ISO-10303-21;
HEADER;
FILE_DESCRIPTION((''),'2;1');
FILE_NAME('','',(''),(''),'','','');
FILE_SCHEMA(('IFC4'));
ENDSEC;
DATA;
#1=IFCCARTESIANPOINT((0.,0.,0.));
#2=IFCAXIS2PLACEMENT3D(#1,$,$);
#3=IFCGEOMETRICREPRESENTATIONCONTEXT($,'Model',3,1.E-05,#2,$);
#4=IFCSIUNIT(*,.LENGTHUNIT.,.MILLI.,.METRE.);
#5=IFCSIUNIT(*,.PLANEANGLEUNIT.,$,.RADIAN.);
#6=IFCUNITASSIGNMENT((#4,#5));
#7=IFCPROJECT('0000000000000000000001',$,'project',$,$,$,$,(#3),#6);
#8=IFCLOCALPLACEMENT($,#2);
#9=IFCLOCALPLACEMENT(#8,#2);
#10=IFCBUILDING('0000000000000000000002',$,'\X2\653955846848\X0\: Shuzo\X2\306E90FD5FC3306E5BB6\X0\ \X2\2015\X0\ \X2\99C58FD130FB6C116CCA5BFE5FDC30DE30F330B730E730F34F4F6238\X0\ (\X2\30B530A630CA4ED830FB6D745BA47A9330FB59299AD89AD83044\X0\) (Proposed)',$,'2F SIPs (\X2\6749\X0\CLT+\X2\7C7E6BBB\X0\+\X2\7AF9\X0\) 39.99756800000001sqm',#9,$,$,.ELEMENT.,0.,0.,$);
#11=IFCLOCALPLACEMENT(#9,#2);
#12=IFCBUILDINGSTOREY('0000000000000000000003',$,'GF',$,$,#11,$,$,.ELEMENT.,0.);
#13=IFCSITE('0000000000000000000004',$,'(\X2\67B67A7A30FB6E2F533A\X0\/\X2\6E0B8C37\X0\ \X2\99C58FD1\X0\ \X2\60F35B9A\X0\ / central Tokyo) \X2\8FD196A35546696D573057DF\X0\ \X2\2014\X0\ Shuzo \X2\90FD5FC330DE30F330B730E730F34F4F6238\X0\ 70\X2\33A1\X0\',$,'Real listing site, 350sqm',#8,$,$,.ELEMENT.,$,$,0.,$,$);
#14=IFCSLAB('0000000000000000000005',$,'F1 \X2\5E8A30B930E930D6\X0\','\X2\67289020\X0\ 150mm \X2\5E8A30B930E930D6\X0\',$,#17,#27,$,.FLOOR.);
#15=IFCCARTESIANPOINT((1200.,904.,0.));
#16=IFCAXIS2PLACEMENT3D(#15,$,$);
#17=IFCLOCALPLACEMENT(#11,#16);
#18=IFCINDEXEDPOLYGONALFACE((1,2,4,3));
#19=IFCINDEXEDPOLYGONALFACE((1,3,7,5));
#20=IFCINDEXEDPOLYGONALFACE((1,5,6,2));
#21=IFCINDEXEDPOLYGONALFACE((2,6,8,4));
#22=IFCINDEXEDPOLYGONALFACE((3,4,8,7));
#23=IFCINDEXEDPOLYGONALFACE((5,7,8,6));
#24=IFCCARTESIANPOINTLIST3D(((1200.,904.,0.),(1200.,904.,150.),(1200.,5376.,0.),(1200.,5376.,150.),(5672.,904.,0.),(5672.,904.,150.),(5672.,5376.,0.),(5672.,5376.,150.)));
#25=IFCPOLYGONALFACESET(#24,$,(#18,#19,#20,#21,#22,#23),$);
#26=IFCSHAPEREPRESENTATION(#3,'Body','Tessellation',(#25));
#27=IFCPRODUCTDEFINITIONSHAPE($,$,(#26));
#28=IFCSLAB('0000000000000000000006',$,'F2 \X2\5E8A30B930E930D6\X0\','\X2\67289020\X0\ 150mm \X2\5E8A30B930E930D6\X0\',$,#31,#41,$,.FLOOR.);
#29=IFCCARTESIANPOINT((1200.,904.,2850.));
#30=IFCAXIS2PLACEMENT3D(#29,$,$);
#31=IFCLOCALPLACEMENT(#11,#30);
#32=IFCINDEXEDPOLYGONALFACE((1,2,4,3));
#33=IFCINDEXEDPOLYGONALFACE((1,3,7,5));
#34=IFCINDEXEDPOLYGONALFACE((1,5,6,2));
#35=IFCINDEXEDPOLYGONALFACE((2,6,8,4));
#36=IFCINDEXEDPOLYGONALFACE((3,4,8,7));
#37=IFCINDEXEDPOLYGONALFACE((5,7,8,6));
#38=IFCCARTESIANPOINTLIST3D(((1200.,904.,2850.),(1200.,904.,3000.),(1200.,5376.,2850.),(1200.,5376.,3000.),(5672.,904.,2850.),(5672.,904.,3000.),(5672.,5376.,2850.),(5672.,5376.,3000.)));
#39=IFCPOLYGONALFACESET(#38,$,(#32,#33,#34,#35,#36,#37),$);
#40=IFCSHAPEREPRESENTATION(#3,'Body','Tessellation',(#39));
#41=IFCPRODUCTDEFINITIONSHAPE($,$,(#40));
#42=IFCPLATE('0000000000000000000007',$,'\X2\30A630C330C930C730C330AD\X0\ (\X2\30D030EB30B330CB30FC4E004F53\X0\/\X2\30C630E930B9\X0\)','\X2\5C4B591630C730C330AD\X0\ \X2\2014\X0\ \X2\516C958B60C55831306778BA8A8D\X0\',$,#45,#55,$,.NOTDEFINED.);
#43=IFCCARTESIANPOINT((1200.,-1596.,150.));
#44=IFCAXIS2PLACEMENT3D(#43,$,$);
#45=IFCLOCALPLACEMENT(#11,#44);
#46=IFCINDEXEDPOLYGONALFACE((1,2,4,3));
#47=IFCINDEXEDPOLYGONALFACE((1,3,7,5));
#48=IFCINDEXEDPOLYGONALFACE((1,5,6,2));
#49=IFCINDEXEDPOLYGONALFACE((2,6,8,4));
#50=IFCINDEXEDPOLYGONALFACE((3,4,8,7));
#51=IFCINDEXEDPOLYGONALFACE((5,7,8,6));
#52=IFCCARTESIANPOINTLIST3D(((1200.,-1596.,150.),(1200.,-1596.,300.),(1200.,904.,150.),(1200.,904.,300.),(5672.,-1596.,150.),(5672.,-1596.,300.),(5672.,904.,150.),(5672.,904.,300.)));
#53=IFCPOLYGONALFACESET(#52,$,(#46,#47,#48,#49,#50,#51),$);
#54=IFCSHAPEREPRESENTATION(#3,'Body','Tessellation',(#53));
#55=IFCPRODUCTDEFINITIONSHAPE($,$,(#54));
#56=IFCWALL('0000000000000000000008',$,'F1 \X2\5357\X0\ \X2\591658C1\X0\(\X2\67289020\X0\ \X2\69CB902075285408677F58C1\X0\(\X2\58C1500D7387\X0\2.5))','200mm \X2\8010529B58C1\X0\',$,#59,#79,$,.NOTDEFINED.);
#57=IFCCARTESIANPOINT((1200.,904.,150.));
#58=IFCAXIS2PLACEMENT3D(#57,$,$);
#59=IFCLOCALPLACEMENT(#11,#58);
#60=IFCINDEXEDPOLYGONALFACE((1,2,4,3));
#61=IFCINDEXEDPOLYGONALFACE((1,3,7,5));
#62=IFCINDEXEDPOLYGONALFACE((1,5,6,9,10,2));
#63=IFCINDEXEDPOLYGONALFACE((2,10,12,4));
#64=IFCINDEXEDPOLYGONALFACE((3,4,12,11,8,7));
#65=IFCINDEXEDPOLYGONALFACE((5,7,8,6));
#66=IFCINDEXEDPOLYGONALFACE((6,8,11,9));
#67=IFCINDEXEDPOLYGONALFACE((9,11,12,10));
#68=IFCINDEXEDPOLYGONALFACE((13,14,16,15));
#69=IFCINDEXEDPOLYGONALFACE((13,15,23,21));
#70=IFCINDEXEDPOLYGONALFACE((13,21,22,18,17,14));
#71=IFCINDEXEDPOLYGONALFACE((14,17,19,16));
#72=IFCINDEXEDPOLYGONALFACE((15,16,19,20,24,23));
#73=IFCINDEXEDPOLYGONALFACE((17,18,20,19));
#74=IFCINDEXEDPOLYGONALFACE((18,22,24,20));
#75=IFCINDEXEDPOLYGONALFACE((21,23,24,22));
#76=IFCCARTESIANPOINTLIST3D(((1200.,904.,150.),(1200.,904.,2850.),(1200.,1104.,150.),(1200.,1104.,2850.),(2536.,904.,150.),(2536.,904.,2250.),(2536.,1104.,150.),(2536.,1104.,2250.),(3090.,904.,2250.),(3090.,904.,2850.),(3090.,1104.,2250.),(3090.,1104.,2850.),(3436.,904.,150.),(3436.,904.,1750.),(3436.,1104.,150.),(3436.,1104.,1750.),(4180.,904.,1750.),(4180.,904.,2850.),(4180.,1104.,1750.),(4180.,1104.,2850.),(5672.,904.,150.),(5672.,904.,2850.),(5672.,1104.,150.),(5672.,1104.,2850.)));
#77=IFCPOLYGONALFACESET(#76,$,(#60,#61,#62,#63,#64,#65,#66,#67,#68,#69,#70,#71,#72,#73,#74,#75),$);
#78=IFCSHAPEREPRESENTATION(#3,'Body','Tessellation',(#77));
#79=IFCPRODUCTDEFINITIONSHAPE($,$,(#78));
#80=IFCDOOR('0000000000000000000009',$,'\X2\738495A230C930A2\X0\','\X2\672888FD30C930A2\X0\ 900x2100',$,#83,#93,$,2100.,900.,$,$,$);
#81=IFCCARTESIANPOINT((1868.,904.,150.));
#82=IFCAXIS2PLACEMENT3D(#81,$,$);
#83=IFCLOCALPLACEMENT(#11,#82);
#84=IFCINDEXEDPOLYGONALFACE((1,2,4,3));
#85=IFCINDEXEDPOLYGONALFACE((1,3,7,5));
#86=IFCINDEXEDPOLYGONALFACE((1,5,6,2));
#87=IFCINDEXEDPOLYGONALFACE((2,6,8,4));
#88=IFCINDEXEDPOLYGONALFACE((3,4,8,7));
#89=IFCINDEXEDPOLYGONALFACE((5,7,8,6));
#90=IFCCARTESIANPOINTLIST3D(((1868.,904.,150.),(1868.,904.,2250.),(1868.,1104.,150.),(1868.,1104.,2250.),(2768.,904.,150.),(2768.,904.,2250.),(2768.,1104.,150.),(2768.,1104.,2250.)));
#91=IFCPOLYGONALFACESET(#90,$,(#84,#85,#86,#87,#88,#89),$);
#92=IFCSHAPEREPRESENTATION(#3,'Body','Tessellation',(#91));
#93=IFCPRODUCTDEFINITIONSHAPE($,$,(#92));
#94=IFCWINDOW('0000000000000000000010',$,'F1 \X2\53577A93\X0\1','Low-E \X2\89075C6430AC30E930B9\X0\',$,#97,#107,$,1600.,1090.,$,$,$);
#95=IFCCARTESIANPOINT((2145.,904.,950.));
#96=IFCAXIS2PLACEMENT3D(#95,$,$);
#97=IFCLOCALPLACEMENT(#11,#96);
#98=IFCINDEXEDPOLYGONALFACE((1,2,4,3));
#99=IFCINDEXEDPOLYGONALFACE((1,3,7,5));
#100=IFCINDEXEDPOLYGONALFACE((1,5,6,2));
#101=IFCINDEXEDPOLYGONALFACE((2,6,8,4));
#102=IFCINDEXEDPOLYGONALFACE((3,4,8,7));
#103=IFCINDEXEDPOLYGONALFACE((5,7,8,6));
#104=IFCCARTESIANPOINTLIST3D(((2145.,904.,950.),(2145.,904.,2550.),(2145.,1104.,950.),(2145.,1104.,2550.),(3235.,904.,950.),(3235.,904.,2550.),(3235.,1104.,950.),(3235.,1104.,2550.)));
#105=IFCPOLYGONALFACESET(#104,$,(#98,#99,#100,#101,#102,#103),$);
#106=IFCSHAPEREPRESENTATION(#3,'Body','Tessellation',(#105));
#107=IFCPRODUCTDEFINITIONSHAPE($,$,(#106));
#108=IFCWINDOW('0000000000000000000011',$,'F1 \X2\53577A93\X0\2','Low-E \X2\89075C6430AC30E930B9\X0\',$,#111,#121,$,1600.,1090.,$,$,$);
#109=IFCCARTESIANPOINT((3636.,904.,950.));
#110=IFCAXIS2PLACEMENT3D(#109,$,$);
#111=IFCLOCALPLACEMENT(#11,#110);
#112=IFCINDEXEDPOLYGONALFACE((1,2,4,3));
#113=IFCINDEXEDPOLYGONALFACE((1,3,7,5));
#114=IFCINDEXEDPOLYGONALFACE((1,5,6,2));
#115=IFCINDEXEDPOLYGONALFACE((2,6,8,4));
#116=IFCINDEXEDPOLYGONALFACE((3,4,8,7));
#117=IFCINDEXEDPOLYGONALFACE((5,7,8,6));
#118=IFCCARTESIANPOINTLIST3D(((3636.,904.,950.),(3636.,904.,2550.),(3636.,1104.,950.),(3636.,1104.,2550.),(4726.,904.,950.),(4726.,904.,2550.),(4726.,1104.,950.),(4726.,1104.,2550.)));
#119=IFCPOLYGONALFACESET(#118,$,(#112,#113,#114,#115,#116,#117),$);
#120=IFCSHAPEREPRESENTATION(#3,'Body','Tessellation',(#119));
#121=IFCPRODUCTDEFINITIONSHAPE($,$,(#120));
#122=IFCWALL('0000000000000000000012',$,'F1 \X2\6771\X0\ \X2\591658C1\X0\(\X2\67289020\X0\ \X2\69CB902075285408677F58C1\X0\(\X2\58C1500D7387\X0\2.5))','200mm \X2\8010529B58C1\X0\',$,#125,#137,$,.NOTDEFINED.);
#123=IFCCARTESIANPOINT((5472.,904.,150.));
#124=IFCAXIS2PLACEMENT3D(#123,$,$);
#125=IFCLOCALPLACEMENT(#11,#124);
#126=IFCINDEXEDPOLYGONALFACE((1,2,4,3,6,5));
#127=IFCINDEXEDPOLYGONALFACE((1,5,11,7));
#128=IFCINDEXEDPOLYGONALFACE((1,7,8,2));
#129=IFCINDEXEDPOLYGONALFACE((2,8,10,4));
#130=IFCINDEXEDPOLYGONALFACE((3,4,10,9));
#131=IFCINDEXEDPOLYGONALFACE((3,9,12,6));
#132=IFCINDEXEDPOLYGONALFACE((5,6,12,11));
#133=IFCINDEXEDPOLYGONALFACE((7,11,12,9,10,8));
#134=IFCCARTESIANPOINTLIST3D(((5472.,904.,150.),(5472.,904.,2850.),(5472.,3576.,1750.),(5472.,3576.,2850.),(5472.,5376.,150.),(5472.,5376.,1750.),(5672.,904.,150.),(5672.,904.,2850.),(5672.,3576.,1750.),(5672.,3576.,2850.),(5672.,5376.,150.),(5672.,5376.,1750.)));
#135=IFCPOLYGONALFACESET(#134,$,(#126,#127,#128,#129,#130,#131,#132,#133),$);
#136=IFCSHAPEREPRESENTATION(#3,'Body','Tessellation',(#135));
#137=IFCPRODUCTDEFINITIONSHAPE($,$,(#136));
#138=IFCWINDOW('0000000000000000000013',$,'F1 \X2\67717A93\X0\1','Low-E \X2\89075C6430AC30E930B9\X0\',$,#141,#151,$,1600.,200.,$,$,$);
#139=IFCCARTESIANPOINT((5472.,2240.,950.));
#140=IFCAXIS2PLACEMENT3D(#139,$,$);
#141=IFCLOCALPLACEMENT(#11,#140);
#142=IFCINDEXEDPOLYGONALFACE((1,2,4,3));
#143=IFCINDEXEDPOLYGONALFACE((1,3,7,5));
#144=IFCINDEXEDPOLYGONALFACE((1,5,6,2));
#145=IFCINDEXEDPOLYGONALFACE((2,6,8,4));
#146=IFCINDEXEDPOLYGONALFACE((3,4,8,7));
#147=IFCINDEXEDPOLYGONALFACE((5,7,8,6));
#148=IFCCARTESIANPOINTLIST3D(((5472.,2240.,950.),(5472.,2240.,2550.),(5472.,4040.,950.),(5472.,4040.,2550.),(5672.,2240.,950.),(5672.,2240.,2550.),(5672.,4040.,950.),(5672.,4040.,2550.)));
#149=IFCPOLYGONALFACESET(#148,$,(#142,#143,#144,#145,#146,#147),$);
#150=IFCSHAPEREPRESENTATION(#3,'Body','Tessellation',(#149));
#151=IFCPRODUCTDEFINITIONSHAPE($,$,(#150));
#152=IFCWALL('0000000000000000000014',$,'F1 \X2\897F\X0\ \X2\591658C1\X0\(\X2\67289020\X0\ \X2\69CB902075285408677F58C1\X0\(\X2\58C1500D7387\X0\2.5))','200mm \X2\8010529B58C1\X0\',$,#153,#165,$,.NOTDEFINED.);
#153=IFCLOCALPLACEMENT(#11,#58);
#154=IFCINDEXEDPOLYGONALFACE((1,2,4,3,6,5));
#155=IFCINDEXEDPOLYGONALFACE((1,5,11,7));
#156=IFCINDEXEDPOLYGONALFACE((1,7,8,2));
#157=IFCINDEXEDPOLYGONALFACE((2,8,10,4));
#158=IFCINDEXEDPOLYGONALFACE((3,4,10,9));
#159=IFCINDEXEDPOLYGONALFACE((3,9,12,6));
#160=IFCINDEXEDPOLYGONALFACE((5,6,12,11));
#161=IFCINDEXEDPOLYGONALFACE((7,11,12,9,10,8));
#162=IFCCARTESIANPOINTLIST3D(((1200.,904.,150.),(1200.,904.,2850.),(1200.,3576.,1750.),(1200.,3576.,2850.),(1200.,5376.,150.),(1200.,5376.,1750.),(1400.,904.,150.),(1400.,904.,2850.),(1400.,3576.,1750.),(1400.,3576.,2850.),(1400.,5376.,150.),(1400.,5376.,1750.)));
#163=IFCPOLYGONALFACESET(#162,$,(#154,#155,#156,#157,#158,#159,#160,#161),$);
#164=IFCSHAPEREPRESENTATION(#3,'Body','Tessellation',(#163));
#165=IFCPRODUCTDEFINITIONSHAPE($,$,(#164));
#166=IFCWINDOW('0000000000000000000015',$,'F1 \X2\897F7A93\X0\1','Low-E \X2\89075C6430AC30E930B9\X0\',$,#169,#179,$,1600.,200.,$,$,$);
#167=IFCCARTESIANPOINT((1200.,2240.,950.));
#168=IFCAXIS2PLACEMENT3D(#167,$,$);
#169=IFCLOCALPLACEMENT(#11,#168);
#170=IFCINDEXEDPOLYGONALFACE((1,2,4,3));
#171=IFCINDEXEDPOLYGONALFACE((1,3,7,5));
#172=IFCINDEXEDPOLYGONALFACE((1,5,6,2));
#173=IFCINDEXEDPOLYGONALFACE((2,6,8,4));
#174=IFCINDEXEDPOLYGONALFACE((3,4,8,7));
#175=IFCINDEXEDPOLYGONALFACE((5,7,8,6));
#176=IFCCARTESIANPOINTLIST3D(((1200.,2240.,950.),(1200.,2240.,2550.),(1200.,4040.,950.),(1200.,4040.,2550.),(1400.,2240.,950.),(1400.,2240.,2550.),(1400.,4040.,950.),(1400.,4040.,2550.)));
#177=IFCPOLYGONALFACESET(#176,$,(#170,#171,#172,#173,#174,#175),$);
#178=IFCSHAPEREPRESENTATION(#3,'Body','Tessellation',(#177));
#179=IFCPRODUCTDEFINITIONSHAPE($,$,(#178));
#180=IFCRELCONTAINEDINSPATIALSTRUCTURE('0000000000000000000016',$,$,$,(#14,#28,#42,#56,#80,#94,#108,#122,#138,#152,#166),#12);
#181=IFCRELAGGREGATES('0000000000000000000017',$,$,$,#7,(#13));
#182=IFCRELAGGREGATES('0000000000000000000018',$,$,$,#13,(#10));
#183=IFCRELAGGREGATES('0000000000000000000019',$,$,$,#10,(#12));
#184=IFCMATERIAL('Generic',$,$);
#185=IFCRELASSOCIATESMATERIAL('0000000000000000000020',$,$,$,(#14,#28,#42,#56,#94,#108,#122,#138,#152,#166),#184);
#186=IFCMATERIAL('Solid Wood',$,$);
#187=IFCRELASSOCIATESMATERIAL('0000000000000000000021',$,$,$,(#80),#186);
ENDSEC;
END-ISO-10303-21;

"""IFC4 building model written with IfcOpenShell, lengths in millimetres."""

from ifc_helpers import new_model, si_unit, frame, frame_2d, origin, place, context, project, spatial, rectangle, extrude, material, element, fill, save


model = new_model("IFC4")

# Units and contexts
model_context = context("Model", 3, precision=1e-05, world=origin())
ifc_project = project(units=[si_unit("LENGTHUNIT", "METRE", prefix="MILLI"), si_unit("PLANEANGLEUNIT", "RADIAN")], contexts=[model_context])

# Site, building, storey
site_placement = place(None, origin())
site = spatial("IfcSite", under=ifc_project, at=site_placement, Name="(架空・港区/渋谷 駅近 想定 / central Tokyo) 近隣商業地域 — Shuzo 都心マンション住戸 70㎡", ObjectType="Real listing site, 350sqm", CompositionType="ELEMENT", RefElevation=0.0)
building_placement = place(site_placement, origin())
building = spatial("IfcBuilding", under=site, at=building_placement, Name="改善案: Shuzoの都心の家 ― 駅近・民泊対応マンション住戸 (サウナ付・浴室窓・天高高い) (Proposed)", ObjectType="2F SIPs (杉CLT+籾殻+竹) 39.99756800000001sqm", CompositionType="ELEMENT", ElevationOfRefHeight=0.0, ElevationOfTerrain=0.0)
storey_placement = place(building_placement, origin())
storey = spatial("IfcBuildingStorey", under=building, at=storey_placement, Name="GF", CompositionType="ELEMENT", Elevation=0.0)

# Slabs
ifc_material_1 = material(Name="Generic")
slab_1_placement = place(storey_placement, frame((1200.0, 904.0, 0.0)))
element("IfcSlab", 1, at=slab_1_placement, inside=storey, material=ifc_material_1, Name="F1 床スラブ", Description="木造 150mm 床スラブ", PredefinedType="FLOOR", context=model_context, shape_type="SweptSolid", body=[
    extrude(rectangle(XDim=4472.0, YDim=4472.0, at=frame_2d((2236.0, 2236.0))), frame((1200.0, 904.0, 0.0)), (0.0, 0.0, 1.0), 150.0),
])
slab_2_placement = place(storey_placement, frame((1200.0, 904.0, 2850.0)))
element("IfcSlab", 2, at=slab_2_placement, inside=storey, material=ifc_material_1, Name="F2 床スラブ", Description="木造 150mm 床スラブ", PredefinedType="FLOOR", context=model_context, shape_type="SweptSolid", body=[
    extrude(rectangle(XDim=4472.0, YDim=4472.0, at=frame_2d((2236.0, 2236.0))), frame((1200.0, 904.0, 2850.0)), (0.0, 0.0, 1.0), 150.0),
])

# Plate
plate_placement = place(storey_placement, frame((1200.0, -1596.0, 150.0)))
element("IfcPlate", 3, at=plate_placement, inside=storey, material=ifc_material_1, Name="ウッドデッキ (バルコニー一体/テラス)", Description="屋外デッキ — 公開情報で確認", PredefinedType="NOTDEFINED", context=model_context, shape_type="SweptSolid", body=[
    extrude(rectangle(XDim=4472.0, YDim=2500.0, at=frame_2d((2236.0, 1250.0))), frame((1200.0, -1596.0, 150.0)), (0.0, 0.0, 1.0), 150.0),
])

# Wall, openings, door, windows
wall_1_placement = place(storey_placement, frame((1200.0, 904.0, 150.0)))
wall_1 = element("IfcWall", 4, at=wall_1_placement, inside=storey, material=ifc_material_1, Name="F1 南 外壁(木造 構造用合板壁(壁倍率2.5))", Description="200mm 耐力壁", PredefinedType="NOTDEFINED", context=model_context, shape_type="SweptSolid", body=[
    extrude(rectangle(XDim=4472.0, YDim=200.0, at=frame_2d((2236.0, 100.0))), frame((1200.0, 904.0, 150.0)), (0.0, 0.0, 1.0), 2700.0),
])
opening_1_placement = place(storey_placement, frame((1868.0, 904.0, 150.0)))
opening_1 = element("IfcOpeningElement", 5, at=opening_1_placement, cuts=wall_1, PredefinedType="NOTDEFINED", context=model_context, shape_type="SweptSolid", body=[
    extrude(rectangle(XDim=900.0, YDim=200.0, at=frame_2d((450.0, 100.0))), frame((1868.0, 904.0, 150.0)), (0.0, 0.0, 1.0), 2100.0),
])
opening_2_placement = place(storey_placement, frame((2145.0, 904.0, 950.0)))
opening_2 = element("IfcOpeningElement", 6, at=opening_2_placement, cuts=wall_1, PredefinedType="NOTDEFINED", context=model_context, shape_type="SweptSolid", body=[
    extrude(rectangle(XDim=1090.0, YDim=200.0, at=frame_2d((545.0, 100.0))), frame((2145.0, 904.0, 950.0)), (0.0, 0.0, 1.0), 1600.0),
])
opening_3_placement = place(storey_placement, frame((3636.0, 904.0, 950.0)))
opening_3 = element("IfcOpeningElement", 7, at=opening_3_placement, cuts=wall_1, PredefinedType="NOTDEFINED", context=model_context, shape_type="SweptSolid", body=[
    extrude(rectangle(XDim=1090.0, YDim=200.0, at=frame_2d((545.0, 100.0))), frame((3636.0, 904.0, 950.0)), (0.0, 0.0, 1.0), 1600.0),
])
ifc_material_2 = material(Name="Solid Wood")
door_placement = place(storey_placement, frame((1868.0, 904.0, 150.0)))
door = element("IfcDoor", 8, at=door_placement, inside=storey, material=ifc_material_2, Name="玄関ドア", Description="木製ドア 900x2100", OverallHeight=2100.0, OverallWidth=900.0, context=model_context, shape_type="SweptSolid", body=[
    extrude(rectangle(XDim=900.0, YDim=200.0, at=frame_2d((450.0, 100.0))), frame((1868.0, 904.0, 150.0)), (0.0, 0.0, 1.0), 2100.0),
])
fill(opening_1, door)
window_1_placement = place(storey_placement, frame((2145.0, 904.0, 950.0)))
window_1 = element("IfcWindow", 9, at=window_1_placement, inside=storey, material=ifc_material_1, Name="F1 南窓1", Description="Low-E 複層ガラス", OverallHeight=1600.0, OverallWidth=1090.0, context=model_context, shape_type="SweptSolid", body=[
    extrude(rectangle(XDim=1090.0, YDim=200.0, at=frame_2d((545.0, 100.0))), frame((2145.0, 904.0, 950.0)), (0.0, 0.0, 1.0), 1600.0),
])
fill(opening_2, window_1)
window_2_placement = place(storey_placement, frame((3636.0, 904.0, 950.0)))
window_2 = element("IfcWindow", 10, at=window_2_placement, inside=storey, material=ifc_material_1, Name="F1 南窓2", Description="Low-E 複層ガラス", OverallHeight=1600.0, OverallWidth=1090.0, context=model_context, shape_type="SweptSolid", body=[
    extrude(rectangle(XDim=1090.0, YDim=200.0, at=frame_2d((545.0, 100.0))), frame((3636.0, 904.0, 950.0)), (0.0, 0.0, 1.0), 1600.0),
])
fill(opening_3, window_2)

# Walls, openings, windows
wall_2_placement = place(storey_placement, frame((5472.0, 904.0, 150.0)))
wall_2 = element("IfcWall", 11, at=wall_2_placement, inside=storey, material=ifc_material_1, Name="F1 東 外壁(木造 構造用合板壁(壁倍率2.5))", Description="200mm 耐力壁", PredefinedType="NOTDEFINED", context=model_context, shape_type="SweptSolid", body=[
    extrude(rectangle(XDim=200.0, YDim=4472.0, at=frame_2d((100.0, 2236.0))), frame((5472.0, 904.0, 150.0)), (0.0, 0.0, 1.0), 2700.0),
])
opening_4_placement = place(storey_placement, frame((5472.0, 2240.0, 950.0)))
opening_4 = element("IfcOpeningElement", 12, at=opening_4_placement, cuts=wall_2, PredefinedType="NOTDEFINED", context=model_context, shape_type="SweptSolid", body=[
    extrude(rectangle(XDim=200.0, YDim=1800.0, at=frame_2d((100.0, 900.0))), frame((5472.0, 2240.0, 950.0)), (0.0, 0.0, 1.0), 1600.0),
])
window_3_placement = place(storey_placement, frame((5472.0, 2240.0, 950.0)))
window_3 = element("IfcWindow", 13, at=window_3_placement, inside=storey, material=ifc_material_1, Name="F1 東窓1", Description="Low-E 複層ガラス", OverallHeight=1600.0, OverallWidth=200.0, context=model_context, shape_type="SweptSolid", body=[
    extrude(rectangle(XDim=200.0, YDim=1800.0, at=frame_2d((100.0, 900.0))), frame((5472.0, 2240.0, 950.0)), (0.0, 0.0, 1.0), 1600.0),
])
fill(opening_4, window_3)
wall_3_placement = place(storey_placement, frame((1200.0, 904.0, 150.0)))
wall_3 = element("IfcWall", 14, at=wall_3_placement, inside=storey, material=ifc_material_1, Name="F1 西 外壁(木造 構造用合板壁(壁倍率2.5))", Description="200mm 耐力壁", PredefinedType="NOTDEFINED", context=model_context, shape_type="SweptSolid", body=[
    extrude(rectangle(XDim=200.0, YDim=4472.0, at=frame_2d((100.0, 2236.0))), frame((1200.0, 904.0, 150.0)), (0.0, 0.0, 1.0), 2700.0),
])
opening_5_placement = place(storey_placement, frame((1200.0, 2240.0, 950.0)))
opening_5 = element("IfcOpeningElement", 15, at=opening_5_placement, cuts=wall_3, PredefinedType="NOTDEFINED", context=model_context, shape_type="SweptSolid", body=[
    extrude(rectangle(XDim=200.0, YDim=1800.0, at=frame_2d((100.0, 900.0))), frame((1200.0, 2240.0, 950.0)), (0.0, 0.0, 1.0), 1600.0),
])
window_4_placement = place(storey_placement, frame((1200.0, 2240.0, 950.0)))
window_4 = element("IfcWindow", 16, at=window_4_placement, inside=storey, material=ifc_material_1, Name="F1 西窓1", Description="Low-E 複層ガラス", OverallHeight=1600.0, OverallWidth=200.0, context=model_context, shape_type="SweptSolid", body=[
    extrude(rectangle(XDim=200.0, YDim=1800.0, at=frame_2d((100.0, 900.0))), frame((1200.0, 2240.0, 950.0)), (0.0, 0.0, 1.0), 1600.0),
])
fill(opening_5, window_4)

save(model, "model.ifc")
